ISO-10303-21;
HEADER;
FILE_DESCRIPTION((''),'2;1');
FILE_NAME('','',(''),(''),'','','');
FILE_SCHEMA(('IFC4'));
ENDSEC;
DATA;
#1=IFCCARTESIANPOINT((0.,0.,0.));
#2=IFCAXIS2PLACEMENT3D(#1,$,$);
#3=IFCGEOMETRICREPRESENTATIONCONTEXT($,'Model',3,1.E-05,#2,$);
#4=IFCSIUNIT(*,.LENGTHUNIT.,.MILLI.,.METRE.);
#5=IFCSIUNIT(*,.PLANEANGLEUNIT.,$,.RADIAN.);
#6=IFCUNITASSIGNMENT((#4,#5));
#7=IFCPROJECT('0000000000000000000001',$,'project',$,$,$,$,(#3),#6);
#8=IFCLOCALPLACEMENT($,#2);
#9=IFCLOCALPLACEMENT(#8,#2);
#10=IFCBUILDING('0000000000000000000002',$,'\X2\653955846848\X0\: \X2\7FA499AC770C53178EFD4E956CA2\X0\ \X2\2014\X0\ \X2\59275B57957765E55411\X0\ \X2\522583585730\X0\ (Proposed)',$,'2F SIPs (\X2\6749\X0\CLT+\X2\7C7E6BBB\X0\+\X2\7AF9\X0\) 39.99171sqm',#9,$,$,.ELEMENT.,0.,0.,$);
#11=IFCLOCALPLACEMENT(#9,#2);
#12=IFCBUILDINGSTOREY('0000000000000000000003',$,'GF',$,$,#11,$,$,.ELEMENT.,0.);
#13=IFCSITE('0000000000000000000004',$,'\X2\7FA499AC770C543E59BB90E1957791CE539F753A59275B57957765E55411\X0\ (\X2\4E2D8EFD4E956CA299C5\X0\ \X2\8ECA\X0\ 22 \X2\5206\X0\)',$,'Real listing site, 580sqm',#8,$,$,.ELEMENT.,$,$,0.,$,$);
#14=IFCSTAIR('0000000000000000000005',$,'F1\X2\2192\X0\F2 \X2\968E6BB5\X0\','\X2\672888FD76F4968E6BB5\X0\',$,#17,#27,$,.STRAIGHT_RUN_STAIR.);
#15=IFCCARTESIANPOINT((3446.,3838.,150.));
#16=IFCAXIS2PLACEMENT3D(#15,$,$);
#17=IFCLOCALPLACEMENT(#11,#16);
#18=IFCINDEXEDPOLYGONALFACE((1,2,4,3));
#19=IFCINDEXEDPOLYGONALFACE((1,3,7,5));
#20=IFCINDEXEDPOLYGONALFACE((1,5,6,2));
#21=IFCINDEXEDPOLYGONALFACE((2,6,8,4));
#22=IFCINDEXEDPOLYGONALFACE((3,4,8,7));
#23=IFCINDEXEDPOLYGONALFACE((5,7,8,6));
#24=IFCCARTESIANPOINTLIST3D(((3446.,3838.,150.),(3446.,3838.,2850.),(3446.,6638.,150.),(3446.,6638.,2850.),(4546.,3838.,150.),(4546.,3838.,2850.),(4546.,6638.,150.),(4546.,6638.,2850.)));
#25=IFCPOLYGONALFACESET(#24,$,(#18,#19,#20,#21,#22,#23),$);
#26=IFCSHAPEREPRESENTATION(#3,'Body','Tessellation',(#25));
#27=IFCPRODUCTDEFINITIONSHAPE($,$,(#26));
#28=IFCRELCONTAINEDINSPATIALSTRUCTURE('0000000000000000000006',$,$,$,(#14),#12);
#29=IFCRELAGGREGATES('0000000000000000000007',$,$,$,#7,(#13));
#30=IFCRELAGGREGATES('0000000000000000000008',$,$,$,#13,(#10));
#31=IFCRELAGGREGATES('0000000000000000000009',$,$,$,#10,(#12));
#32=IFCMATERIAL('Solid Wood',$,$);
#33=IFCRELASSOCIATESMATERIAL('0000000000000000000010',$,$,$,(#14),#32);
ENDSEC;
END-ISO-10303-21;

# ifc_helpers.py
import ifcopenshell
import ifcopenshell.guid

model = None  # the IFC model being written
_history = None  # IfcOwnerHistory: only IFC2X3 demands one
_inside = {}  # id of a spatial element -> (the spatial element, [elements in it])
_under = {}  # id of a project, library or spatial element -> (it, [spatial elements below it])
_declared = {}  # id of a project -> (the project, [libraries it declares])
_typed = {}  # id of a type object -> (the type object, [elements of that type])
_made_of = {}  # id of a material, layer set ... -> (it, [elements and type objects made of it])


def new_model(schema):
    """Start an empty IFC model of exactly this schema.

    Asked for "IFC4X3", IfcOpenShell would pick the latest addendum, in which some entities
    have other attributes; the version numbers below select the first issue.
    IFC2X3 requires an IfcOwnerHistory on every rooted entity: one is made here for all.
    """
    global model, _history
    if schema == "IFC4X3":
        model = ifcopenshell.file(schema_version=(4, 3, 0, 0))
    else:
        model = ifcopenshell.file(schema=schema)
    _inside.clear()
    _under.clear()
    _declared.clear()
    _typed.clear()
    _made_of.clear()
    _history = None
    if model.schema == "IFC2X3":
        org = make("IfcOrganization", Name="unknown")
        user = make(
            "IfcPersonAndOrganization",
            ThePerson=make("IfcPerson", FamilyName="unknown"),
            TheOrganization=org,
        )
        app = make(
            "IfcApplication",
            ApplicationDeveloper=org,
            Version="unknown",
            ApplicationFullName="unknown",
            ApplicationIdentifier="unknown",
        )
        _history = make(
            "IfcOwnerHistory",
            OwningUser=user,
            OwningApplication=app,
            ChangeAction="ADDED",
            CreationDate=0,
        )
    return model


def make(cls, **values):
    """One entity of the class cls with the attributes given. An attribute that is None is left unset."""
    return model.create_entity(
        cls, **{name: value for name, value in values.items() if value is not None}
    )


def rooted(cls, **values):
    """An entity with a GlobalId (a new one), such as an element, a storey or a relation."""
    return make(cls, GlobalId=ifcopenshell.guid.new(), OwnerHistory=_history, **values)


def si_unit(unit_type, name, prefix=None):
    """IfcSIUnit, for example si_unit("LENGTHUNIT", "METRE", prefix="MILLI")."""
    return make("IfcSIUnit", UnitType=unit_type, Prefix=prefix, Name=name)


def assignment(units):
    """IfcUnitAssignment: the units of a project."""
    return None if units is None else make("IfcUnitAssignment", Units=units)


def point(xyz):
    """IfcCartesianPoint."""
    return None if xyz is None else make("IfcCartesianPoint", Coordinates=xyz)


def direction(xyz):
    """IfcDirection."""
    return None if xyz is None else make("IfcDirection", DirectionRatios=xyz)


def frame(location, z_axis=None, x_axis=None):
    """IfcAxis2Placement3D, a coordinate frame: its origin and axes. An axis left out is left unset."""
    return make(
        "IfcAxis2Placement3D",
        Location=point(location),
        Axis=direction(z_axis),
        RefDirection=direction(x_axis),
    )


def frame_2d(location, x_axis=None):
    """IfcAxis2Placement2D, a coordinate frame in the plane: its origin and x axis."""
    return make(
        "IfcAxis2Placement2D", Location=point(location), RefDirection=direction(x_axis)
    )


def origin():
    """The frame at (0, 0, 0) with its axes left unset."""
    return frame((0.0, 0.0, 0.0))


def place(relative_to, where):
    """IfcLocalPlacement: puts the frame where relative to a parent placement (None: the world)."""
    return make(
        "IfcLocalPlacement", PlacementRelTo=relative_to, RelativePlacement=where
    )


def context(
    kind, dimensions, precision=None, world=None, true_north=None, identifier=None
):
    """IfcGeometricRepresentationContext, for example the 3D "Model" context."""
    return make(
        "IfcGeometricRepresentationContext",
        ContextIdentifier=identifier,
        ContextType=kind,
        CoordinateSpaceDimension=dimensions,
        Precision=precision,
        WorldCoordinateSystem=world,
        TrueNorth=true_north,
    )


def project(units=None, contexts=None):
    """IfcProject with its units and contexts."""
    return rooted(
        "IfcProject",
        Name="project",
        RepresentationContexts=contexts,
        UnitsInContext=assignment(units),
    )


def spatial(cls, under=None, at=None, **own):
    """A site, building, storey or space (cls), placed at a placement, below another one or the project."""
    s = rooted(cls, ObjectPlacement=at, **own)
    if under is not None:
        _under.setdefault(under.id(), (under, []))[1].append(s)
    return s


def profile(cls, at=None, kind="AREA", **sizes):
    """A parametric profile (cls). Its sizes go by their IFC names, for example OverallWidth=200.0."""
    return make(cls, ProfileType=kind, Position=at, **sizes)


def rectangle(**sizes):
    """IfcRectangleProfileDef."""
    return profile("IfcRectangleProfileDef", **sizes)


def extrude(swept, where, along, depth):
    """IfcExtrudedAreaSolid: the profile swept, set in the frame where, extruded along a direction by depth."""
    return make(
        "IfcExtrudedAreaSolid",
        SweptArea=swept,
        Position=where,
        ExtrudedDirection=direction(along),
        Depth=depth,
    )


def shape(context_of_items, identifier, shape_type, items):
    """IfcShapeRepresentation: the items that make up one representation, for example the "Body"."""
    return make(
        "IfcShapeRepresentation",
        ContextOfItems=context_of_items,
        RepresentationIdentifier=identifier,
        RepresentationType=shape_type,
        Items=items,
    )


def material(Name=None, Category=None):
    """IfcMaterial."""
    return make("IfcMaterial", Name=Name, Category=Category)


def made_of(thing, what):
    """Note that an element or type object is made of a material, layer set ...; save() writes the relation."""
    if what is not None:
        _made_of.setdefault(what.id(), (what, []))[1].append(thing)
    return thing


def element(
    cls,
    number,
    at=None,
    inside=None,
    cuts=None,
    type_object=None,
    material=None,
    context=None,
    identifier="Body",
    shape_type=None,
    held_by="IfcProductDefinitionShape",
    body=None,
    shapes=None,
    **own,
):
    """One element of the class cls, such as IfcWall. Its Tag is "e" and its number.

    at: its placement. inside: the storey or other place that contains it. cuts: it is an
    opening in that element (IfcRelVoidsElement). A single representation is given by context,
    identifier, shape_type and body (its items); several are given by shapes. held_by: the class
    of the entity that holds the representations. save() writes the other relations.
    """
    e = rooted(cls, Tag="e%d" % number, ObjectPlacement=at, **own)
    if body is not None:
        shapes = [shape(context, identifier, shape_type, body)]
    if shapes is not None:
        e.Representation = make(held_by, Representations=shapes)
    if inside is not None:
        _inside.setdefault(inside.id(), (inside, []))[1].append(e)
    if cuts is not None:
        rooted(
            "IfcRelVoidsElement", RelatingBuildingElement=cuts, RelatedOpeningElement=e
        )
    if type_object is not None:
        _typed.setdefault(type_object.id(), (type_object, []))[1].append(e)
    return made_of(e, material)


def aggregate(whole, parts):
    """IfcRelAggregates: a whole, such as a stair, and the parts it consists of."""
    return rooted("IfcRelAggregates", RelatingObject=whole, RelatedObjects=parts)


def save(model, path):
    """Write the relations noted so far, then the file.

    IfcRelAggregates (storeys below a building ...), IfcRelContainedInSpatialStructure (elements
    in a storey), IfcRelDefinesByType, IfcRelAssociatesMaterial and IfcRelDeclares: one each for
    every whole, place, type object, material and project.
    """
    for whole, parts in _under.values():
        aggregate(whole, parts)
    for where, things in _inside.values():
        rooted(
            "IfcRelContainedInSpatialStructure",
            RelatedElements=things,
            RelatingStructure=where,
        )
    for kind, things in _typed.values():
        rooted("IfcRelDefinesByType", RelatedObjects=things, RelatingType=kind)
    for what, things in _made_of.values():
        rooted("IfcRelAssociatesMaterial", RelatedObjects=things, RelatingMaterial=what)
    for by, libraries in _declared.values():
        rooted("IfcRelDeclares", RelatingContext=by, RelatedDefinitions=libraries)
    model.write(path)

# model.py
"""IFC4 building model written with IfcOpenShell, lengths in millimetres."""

from ifc_helpers import new_model, si_unit, frame, frame_2d, origin, place, context, project, spatial, rectangle, extrude, material, element, save


model = new_model("IFC4")

# Units and contexts
model_context = context("Model", 3, precision=1e-05, world=origin())
ifc_project = project(units=[si_unit("LENGTHUNIT", "METRE", prefix="MILLI"), si_unit("PLANEANGLEUNIT", "RADIAN")], contexts=[model_context])

# Site, building, storey
site_placement = place(None, origin())
site = spatial("IfcSite", under=ifc_project, at=site_placement, Name="群馬県吾妻郡長野原町大字長日向 (中軽井沢駅 車 22 分)", ObjectType="Real listing site, 580sqm", CompositionType="ELEMENT", RefElevation=0.0)
building_placement = place(site_placement, origin())
building = spatial("IfcBuilding", under=site, at=building_placement, Name="改善案: 群馬県北軽井沢 — 大字長日向 別荘地 (Proposed)", ObjectType="2F SIPs (杉CLT+籾殻+竹) 39.99171sqm", CompositionType="ELEMENT", ElevationOfRefHeight=0.0, ElevationOfTerrain=0.0)
storey_placement = place(building_placement, origin())
storey = spatial("IfcBuildingStorey", under=building, at=storey_placement, Name="GF", CompositionType="ELEMENT", Elevation=0.0)

# Stair
ifc_material_1 = material(Name="Solid Wood")
stair_placement = place(storey_placement, frame((3446.0, 3838.0, 150.0)))
element("IfcStair", 1, at=stair_placement, inside=storey, material=ifc_material_1, Name="F1→F2 階段", Description="木製直階段", PredefinedType="STRAIGHT_RUN_STAIR", context=model_context, shape_type="SweptSolid", body=[
    extrude(rectangle(XDim=1100.0, YDim=2800.0, at=frame_2d((550.0, 1400.0))), frame((3446.0, 3838.0, 150.0)), (0.0, 0.0, 1.0), 2700.0),
])

save(model, "model.ifc")
